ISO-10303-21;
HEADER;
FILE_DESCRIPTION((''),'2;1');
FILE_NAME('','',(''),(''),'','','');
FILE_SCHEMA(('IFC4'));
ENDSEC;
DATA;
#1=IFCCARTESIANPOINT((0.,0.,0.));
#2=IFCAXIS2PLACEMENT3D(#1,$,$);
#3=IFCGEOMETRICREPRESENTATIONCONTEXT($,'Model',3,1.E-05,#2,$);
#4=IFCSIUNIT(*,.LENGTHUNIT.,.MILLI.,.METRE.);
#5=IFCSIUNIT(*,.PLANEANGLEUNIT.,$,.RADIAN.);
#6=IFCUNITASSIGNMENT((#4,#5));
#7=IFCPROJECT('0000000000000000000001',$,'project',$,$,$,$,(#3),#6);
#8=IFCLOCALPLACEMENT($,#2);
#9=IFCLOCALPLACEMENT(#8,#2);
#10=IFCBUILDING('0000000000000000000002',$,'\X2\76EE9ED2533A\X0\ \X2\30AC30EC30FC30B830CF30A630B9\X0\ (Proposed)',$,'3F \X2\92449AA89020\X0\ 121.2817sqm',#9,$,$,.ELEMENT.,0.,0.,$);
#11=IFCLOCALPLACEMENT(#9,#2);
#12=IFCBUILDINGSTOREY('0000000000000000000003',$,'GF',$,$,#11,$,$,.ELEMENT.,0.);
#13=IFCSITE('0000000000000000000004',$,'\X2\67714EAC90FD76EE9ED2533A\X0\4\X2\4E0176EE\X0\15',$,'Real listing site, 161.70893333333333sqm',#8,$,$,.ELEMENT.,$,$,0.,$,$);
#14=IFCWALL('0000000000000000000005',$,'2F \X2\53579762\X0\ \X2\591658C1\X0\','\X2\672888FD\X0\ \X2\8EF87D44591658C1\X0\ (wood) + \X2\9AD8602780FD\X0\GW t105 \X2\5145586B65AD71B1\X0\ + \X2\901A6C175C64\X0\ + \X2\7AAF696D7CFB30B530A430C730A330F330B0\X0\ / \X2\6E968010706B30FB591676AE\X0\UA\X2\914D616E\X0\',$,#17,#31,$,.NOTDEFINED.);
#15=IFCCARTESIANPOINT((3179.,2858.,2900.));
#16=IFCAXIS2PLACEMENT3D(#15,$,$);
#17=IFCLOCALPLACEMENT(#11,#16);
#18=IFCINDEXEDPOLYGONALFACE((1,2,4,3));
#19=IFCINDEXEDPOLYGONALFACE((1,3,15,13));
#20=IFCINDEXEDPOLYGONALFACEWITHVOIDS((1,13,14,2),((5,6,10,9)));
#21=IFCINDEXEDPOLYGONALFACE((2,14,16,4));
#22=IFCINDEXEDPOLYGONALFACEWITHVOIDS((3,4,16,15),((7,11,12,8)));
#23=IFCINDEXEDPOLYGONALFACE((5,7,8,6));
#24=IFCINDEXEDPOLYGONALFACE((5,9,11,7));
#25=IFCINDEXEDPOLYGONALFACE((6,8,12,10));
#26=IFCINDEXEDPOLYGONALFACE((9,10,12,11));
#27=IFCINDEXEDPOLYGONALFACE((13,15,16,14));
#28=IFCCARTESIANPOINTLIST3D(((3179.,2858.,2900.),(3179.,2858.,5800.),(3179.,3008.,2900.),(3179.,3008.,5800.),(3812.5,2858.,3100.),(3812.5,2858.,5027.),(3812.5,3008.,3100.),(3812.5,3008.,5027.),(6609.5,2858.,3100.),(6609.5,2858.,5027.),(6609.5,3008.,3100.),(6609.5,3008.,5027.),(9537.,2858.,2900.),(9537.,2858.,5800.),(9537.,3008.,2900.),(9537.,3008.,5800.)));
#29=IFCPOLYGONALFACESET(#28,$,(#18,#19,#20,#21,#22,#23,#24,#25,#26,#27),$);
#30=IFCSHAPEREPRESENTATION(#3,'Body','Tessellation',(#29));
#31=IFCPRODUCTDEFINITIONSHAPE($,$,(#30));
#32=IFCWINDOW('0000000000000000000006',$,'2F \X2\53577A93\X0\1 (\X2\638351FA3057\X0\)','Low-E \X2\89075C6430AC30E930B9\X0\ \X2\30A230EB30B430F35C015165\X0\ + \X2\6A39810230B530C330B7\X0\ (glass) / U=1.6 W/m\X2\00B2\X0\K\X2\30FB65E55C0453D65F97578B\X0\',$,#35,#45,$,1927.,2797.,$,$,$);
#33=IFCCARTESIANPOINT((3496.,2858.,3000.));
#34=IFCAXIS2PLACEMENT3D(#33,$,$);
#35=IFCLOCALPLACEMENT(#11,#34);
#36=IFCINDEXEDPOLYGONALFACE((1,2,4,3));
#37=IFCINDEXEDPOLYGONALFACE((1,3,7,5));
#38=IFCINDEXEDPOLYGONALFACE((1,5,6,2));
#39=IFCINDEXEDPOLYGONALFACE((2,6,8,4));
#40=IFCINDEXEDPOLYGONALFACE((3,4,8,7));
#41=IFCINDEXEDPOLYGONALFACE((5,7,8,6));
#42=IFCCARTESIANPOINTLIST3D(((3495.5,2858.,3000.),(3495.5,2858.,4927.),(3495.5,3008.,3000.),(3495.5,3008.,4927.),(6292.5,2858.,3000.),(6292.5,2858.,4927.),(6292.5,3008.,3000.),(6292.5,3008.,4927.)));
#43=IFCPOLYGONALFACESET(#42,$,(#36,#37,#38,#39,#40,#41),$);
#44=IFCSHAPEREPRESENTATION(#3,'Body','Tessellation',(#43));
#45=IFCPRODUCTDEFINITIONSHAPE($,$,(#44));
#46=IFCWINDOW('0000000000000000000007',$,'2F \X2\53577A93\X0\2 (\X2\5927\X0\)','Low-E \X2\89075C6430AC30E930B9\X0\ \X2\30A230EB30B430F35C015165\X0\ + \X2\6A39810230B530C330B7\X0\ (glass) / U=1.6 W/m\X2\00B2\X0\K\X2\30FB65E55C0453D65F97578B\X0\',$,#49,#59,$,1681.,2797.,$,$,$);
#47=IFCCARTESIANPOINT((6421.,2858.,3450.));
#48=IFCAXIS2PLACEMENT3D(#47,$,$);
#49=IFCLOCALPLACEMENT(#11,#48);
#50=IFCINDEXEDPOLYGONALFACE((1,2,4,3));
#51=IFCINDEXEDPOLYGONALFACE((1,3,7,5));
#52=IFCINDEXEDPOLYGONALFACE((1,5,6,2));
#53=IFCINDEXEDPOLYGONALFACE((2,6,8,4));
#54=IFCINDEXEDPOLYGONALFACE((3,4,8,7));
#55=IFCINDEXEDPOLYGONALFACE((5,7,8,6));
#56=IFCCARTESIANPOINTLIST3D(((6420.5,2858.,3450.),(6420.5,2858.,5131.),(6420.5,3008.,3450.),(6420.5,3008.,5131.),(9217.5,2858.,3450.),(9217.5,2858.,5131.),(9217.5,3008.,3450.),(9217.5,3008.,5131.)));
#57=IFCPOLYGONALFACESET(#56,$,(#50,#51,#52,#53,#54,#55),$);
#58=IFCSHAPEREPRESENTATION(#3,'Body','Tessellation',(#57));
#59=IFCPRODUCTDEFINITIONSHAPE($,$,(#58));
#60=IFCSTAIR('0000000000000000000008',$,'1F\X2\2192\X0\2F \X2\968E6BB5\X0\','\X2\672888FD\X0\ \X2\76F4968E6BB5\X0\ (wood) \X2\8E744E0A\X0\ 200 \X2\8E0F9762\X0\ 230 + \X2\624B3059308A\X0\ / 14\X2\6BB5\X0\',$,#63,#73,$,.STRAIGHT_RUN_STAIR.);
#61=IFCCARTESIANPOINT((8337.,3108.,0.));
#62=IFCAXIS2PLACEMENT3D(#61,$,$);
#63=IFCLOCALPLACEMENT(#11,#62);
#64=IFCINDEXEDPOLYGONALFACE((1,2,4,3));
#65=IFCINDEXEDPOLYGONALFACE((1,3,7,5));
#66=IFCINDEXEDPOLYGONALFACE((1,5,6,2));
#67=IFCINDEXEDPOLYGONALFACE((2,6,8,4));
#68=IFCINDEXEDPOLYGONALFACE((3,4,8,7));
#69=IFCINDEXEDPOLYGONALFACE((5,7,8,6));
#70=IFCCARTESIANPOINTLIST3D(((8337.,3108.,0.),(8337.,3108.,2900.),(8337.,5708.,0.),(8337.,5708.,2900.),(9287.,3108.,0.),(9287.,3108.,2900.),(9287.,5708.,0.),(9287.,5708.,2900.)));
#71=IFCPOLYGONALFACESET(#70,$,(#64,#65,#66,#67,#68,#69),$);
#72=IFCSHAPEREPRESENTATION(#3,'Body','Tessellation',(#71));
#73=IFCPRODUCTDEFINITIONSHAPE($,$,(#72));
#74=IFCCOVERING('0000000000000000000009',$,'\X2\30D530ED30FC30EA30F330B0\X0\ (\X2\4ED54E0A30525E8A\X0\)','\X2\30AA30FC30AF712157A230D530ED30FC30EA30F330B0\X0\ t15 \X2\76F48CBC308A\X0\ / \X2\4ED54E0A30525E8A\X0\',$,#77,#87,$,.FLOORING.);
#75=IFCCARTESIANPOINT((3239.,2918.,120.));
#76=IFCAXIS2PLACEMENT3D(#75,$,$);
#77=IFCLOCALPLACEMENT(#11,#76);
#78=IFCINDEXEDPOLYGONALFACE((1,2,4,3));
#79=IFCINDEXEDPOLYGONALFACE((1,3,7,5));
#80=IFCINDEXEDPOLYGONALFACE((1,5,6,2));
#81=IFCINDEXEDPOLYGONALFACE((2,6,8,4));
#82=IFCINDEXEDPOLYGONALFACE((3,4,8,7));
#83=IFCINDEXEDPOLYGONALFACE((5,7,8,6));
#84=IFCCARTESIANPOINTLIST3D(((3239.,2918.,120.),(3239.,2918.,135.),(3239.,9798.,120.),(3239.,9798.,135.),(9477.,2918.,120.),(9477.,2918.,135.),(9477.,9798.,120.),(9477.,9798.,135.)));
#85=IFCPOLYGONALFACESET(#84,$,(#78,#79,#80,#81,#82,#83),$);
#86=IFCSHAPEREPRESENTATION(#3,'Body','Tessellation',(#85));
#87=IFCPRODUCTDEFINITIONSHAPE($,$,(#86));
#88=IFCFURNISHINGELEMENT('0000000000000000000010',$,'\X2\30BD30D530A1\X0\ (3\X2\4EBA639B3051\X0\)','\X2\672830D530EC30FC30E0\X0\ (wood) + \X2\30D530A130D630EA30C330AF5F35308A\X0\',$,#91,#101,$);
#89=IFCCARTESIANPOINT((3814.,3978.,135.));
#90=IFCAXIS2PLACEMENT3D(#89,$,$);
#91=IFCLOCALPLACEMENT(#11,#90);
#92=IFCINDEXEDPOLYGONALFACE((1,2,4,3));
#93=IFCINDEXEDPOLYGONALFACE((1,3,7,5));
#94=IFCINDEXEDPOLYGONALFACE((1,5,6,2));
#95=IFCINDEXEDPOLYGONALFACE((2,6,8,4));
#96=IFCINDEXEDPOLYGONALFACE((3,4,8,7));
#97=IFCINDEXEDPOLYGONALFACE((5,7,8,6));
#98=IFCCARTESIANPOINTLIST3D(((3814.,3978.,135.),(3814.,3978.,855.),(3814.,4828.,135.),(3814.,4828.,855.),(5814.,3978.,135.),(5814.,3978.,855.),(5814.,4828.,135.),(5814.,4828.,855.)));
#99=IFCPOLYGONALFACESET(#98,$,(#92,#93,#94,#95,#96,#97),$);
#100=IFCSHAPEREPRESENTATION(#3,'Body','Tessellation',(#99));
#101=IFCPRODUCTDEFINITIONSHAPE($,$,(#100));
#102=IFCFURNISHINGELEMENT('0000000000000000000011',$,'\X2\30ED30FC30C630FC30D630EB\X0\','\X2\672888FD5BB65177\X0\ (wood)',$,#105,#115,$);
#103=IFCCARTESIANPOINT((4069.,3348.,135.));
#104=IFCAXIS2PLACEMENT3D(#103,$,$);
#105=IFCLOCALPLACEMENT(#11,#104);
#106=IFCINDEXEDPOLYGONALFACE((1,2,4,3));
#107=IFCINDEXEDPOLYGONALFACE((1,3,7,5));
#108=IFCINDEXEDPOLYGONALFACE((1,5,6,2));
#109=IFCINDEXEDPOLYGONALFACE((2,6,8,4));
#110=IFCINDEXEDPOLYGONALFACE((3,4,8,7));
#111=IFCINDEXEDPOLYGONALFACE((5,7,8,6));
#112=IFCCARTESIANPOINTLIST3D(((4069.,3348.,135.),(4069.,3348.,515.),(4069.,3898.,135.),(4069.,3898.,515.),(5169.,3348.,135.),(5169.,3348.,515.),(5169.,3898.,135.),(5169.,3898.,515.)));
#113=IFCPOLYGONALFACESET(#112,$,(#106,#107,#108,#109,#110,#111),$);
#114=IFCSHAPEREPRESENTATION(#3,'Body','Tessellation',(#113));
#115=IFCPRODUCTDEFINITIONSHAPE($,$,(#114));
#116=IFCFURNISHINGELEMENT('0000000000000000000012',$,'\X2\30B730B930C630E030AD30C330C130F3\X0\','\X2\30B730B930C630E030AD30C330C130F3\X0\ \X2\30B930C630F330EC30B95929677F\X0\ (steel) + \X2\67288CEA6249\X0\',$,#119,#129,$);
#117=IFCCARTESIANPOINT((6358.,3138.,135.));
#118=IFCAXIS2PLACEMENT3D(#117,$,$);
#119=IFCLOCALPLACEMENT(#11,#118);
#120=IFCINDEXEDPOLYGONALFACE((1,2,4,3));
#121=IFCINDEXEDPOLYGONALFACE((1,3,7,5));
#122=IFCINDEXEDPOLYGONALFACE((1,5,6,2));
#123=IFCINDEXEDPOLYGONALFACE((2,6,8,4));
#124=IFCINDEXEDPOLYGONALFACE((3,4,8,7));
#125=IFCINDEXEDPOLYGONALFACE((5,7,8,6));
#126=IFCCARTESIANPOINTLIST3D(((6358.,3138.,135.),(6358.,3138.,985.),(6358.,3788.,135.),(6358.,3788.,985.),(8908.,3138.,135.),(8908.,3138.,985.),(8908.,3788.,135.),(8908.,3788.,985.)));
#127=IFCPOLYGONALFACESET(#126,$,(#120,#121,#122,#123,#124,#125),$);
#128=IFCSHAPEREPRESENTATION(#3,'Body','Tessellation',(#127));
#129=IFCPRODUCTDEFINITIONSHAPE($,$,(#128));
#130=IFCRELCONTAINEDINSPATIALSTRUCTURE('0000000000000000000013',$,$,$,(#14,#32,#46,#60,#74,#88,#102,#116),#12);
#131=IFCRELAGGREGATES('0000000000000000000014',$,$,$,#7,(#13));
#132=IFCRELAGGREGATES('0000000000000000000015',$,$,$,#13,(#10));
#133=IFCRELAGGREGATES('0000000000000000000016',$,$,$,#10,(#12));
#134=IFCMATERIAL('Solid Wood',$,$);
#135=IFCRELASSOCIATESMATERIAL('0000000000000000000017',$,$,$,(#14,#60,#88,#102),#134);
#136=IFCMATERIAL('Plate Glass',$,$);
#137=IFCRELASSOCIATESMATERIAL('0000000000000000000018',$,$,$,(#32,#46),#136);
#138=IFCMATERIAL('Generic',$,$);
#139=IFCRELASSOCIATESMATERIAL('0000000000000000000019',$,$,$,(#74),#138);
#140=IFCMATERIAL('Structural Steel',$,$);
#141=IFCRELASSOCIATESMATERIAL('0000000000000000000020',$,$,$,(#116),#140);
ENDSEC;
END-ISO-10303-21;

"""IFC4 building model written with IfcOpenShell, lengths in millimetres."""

from ifc_helpers import new_model, si_unit, frame, frame_2d, origin, place, context, project, spatial, rectangle, extrude, material, element, fill, save


model = new_model("IFC4")

# Units and contexts
model_context = context("Model", 3, precision=1e-05, world=origin())
ifc_project = project(units=[si_unit("LENGTHUNIT", "METRE", prefix="MILLI"), si_unit("PLANEANGLEUNIT", "RADIAN")], contexts=[model_context])

# Site, building, storey
site_placement = place(None, origin())
site = spatial("IfcSite", under=ifc_project, at=site_placement, Name="東京都目黒区4丁目15", ObjectType="Real listing site, 161.70893333333333sqm", CompositionType="ELEMENT", RefElevation=0.0)
building_placement = place(site_placement, origin())
building = spatial("IfcBuilding", under=site, at=building_placement, Name="目黒区 ガレージハウス (Proposed)", ObjectType="3F 鉄骨造 121.2817sqm", CompositionType="ELEMENT", ElevationOfRefHeight=0.0, ElevationOfTerrain=0.0)
storey_placement = place(building_placement, origin())
storey = spatial("IfcBuildingStorey", under=building, at=storey_placement, Name="GF", CompositionType="ELEMENT", Elevation=0.0)

# Shared definitions
ifc_material_1 = material(Name="Solid Wood")

# Shared definitions
ifc_material_2 = material(Name="Plate Glass")

# Wall, openings, windows
wall_1_placement = place(storey_placement, frame((3179.0, 2858.0, 2900.0)))
wall_1 = element("IfcWall", 1, at=wall_1_placement, inside=storey, material=ifc_material_1, Name="2F 南面 外壁", Description="木製 軸組外壁 (wood) + 高性能GW t105 充填断熱 + 通気層 + 窯業系サイディング / 準耐火・外皮UA配慮", PredefinedType="NOTDEFINED", context=model_context, shape_type="SweptSolid", body=[
    extrude(rectangle(XDim=6358.0, YDim=150.0, at=frame_2d((3179.0, 75.0))), frame((3179.0, 2858.0, 2900.0)), (0.0, 0.0, 1.0), 2900.0),
])
opening_1_placement = place(storey_placement, frame((3496.0, 2858.0, 3000.0)))
opening_1 = element("IfcOpeningElement", 2, at=opening_1_placement, cuts=wall_1, PredefinedType="NOTDEFINED", context=model_context, shape_type="SweptSolid", body=[
    extrude(rectangle(XDim=2797.0, YDim=150.0, at=frame_2d((1398.0, 75.0))), frame((3496.0, 2858.0, 3000.0)), (0.0, 0.0, 1.0), 1927.0),
])
opening_2_placement = place(storey_placement, frame((6421.0, 2858.0, 3450.0)))
opening_2 = element("IfcOpeningElement", 3, at=opening_2_placement, cuts=wall_1, PredefinedType="NOTDEFINED", context=model_context, shape_type="SweptSolid", body=[
    extrude(rectangle(XDim=2797.0, YDim=150.0, at=frame_2d((1398.0, 75.0))), frame((6421.0, 2858.0, 3450.0)), (0.0, 0.0, 1.0), 1681.0),
])
window_1_placement = place(storey_placement, frame((3496.0, 2858.0, 3000.0)))
window_1 = element("IfcWindow", 4, at=window_1_placement, inside=storey, material=ifc_material_2, Name="2F 南窓1 (掃出し)", Description="Low-E 複層ガラス アルゴン封入 + 樹脂サッシ (glass) / U=1.6 W/m²K・日射取得型", OverallHeight=1927.0, OverallWidth=2797.0, context=model_context, shape_type="SweptSolid", body=[
    extrude(rectangle(XDim=2797.0, YDim=150.0, at=frame_2d((1398.0, 75.0))), frame((3496.0, 2858.0, 3000.0)), (0.0, 0.0, 1.0), 1927.0),
])
fill(opening_1, window_1)
window_2_placement = place(storey_placement, frame((6421.0, 2858.0, 3450.0)))
window_2 = element("IfcWindow", 5, at=window_2_placement, inside=storey, material=ifc_material_2, Name="2F 南窓2 (大)", Description="Low-E 複層ガラス アルゴン封入 + 樹脂サッシ (glass) / U=1.6 W/m²K・日射取得型", OverallHeight=1681.0, OverallWidth=2797.0, context=model_context, shape_type="SweptSolid", body=[
    extrude(rectangle(XDim=2797.0, YDim=150.0, at=frame_2d((1398.0, 75.0))), frame((6421.0, 2858.0, 3450.0)), (0.0, 0.0, 1.0), 1681.0),
])
fill(opening_2, window_2)

# Stair
stair_placement = place(storey_placement, frame((8337.0, 3108.0, 0.0)))
element("IfcStair", 6, at=stair_placement, inside=storey, material=ifc_material_1, Name="1F→2F 階段", Description="木製 直階段 (wood) 蹴上 200 踏面 230 + 手すり / 14段", PredefinedType="STRAIGHT_RUN_STAIR", context=model_context, shape_type="SweptSolid", body=[
    extrude(rectangle(XDim=950.0, YDim=2600.0, at=frame_2d((475.0, 1300.0))), frame((8337.0, 3108.0, 0.0)), (0.0, 0.0, 1.0), 2900.0),
])

# Covering
ifc_material_3 = material(Name="Generic")
covering_placement = place(storey_placement, frame((3239.0, 2918.0, 120.0)))
element("IfcCovering", 7, at=covering_placement, inside=storey, material=ifc_material_3, Name="フローリング (仕上げ床)", Description="オーク無垢フローリング t15 直貼り / 仕上げ床", PredefinedType="FLOORING", context=model_context, shape_type="SweptSolid", body=[
    extrude(rectangle(XDim=6238.0, YDim=6880.0, at=frame_2d((3119.0, 3440.0))), frame((3239.0, 2918.0, 120.0)), (0.0, 0.0, 1.0), 15.0),
])

# Furnishing elements
furnishing_1_placement = place(storey_placement, frame((3814.0, 3978.0, 135.0)))
element("IfcFurnishingElement", 8, at=furnishing_1_placement, inside=storey, material=ifc_material_1, Name="ソファ (3人掛け)", Description="木フレーム (wood) + ファブリック張り", context=model_context, shape_type="SweptSolid", body=[
    extrude(rectangle(XDim=2000.0, YDim=850.0, at=frame_2d((1000.0, 425.0))), frame((3814.0, 3978.0, 135.0)), (0.0, 0.0, 1.0), 720.0),
])
furnishing_2_placement = place(storey_placement, frame((4069.0, 3348.0, 135.0)))
element("IfcFurnishingElement", 9, at=furnishing_2_placement, inside=storey, material=ifc_material_1, Name="ローテーブル", Description="木製家具 (wood)", context=model_context, shape_type="SweptSolid", body=[
    extrude(rectangle(XDim=1100.0, YDim=550.0, at=frame_2d((550.0, 275.0))), frame((4069.0, 3348.0, 135.0)), (0.0, 0.0, 1.0), 380.0),
])
ifc_material_4 = material(Name="Structural Steel")
furnishing_3_placement = place(storey_placement, frame((6358.0, 3138.0, 135.0)))
element("IfcFurnishingElement", 10, at=furnishing_3_placement, inside=storey, material=ifc_material_4, Name="システムキッチン", Description="システムキッチン ステンレス天板 (steel) + 木質扉", context=model_context, shape_type="SweptSolid", body=[
    extrude(rectangle(XDim=2550.0, YDim=650.0, at=frame_2d((1275.0, 325.0))), frame((6358.0, 3138.0, 135.0)), (0.0, 0.0, 1.0), 850.0),
])

save(model, "model.ifc")
